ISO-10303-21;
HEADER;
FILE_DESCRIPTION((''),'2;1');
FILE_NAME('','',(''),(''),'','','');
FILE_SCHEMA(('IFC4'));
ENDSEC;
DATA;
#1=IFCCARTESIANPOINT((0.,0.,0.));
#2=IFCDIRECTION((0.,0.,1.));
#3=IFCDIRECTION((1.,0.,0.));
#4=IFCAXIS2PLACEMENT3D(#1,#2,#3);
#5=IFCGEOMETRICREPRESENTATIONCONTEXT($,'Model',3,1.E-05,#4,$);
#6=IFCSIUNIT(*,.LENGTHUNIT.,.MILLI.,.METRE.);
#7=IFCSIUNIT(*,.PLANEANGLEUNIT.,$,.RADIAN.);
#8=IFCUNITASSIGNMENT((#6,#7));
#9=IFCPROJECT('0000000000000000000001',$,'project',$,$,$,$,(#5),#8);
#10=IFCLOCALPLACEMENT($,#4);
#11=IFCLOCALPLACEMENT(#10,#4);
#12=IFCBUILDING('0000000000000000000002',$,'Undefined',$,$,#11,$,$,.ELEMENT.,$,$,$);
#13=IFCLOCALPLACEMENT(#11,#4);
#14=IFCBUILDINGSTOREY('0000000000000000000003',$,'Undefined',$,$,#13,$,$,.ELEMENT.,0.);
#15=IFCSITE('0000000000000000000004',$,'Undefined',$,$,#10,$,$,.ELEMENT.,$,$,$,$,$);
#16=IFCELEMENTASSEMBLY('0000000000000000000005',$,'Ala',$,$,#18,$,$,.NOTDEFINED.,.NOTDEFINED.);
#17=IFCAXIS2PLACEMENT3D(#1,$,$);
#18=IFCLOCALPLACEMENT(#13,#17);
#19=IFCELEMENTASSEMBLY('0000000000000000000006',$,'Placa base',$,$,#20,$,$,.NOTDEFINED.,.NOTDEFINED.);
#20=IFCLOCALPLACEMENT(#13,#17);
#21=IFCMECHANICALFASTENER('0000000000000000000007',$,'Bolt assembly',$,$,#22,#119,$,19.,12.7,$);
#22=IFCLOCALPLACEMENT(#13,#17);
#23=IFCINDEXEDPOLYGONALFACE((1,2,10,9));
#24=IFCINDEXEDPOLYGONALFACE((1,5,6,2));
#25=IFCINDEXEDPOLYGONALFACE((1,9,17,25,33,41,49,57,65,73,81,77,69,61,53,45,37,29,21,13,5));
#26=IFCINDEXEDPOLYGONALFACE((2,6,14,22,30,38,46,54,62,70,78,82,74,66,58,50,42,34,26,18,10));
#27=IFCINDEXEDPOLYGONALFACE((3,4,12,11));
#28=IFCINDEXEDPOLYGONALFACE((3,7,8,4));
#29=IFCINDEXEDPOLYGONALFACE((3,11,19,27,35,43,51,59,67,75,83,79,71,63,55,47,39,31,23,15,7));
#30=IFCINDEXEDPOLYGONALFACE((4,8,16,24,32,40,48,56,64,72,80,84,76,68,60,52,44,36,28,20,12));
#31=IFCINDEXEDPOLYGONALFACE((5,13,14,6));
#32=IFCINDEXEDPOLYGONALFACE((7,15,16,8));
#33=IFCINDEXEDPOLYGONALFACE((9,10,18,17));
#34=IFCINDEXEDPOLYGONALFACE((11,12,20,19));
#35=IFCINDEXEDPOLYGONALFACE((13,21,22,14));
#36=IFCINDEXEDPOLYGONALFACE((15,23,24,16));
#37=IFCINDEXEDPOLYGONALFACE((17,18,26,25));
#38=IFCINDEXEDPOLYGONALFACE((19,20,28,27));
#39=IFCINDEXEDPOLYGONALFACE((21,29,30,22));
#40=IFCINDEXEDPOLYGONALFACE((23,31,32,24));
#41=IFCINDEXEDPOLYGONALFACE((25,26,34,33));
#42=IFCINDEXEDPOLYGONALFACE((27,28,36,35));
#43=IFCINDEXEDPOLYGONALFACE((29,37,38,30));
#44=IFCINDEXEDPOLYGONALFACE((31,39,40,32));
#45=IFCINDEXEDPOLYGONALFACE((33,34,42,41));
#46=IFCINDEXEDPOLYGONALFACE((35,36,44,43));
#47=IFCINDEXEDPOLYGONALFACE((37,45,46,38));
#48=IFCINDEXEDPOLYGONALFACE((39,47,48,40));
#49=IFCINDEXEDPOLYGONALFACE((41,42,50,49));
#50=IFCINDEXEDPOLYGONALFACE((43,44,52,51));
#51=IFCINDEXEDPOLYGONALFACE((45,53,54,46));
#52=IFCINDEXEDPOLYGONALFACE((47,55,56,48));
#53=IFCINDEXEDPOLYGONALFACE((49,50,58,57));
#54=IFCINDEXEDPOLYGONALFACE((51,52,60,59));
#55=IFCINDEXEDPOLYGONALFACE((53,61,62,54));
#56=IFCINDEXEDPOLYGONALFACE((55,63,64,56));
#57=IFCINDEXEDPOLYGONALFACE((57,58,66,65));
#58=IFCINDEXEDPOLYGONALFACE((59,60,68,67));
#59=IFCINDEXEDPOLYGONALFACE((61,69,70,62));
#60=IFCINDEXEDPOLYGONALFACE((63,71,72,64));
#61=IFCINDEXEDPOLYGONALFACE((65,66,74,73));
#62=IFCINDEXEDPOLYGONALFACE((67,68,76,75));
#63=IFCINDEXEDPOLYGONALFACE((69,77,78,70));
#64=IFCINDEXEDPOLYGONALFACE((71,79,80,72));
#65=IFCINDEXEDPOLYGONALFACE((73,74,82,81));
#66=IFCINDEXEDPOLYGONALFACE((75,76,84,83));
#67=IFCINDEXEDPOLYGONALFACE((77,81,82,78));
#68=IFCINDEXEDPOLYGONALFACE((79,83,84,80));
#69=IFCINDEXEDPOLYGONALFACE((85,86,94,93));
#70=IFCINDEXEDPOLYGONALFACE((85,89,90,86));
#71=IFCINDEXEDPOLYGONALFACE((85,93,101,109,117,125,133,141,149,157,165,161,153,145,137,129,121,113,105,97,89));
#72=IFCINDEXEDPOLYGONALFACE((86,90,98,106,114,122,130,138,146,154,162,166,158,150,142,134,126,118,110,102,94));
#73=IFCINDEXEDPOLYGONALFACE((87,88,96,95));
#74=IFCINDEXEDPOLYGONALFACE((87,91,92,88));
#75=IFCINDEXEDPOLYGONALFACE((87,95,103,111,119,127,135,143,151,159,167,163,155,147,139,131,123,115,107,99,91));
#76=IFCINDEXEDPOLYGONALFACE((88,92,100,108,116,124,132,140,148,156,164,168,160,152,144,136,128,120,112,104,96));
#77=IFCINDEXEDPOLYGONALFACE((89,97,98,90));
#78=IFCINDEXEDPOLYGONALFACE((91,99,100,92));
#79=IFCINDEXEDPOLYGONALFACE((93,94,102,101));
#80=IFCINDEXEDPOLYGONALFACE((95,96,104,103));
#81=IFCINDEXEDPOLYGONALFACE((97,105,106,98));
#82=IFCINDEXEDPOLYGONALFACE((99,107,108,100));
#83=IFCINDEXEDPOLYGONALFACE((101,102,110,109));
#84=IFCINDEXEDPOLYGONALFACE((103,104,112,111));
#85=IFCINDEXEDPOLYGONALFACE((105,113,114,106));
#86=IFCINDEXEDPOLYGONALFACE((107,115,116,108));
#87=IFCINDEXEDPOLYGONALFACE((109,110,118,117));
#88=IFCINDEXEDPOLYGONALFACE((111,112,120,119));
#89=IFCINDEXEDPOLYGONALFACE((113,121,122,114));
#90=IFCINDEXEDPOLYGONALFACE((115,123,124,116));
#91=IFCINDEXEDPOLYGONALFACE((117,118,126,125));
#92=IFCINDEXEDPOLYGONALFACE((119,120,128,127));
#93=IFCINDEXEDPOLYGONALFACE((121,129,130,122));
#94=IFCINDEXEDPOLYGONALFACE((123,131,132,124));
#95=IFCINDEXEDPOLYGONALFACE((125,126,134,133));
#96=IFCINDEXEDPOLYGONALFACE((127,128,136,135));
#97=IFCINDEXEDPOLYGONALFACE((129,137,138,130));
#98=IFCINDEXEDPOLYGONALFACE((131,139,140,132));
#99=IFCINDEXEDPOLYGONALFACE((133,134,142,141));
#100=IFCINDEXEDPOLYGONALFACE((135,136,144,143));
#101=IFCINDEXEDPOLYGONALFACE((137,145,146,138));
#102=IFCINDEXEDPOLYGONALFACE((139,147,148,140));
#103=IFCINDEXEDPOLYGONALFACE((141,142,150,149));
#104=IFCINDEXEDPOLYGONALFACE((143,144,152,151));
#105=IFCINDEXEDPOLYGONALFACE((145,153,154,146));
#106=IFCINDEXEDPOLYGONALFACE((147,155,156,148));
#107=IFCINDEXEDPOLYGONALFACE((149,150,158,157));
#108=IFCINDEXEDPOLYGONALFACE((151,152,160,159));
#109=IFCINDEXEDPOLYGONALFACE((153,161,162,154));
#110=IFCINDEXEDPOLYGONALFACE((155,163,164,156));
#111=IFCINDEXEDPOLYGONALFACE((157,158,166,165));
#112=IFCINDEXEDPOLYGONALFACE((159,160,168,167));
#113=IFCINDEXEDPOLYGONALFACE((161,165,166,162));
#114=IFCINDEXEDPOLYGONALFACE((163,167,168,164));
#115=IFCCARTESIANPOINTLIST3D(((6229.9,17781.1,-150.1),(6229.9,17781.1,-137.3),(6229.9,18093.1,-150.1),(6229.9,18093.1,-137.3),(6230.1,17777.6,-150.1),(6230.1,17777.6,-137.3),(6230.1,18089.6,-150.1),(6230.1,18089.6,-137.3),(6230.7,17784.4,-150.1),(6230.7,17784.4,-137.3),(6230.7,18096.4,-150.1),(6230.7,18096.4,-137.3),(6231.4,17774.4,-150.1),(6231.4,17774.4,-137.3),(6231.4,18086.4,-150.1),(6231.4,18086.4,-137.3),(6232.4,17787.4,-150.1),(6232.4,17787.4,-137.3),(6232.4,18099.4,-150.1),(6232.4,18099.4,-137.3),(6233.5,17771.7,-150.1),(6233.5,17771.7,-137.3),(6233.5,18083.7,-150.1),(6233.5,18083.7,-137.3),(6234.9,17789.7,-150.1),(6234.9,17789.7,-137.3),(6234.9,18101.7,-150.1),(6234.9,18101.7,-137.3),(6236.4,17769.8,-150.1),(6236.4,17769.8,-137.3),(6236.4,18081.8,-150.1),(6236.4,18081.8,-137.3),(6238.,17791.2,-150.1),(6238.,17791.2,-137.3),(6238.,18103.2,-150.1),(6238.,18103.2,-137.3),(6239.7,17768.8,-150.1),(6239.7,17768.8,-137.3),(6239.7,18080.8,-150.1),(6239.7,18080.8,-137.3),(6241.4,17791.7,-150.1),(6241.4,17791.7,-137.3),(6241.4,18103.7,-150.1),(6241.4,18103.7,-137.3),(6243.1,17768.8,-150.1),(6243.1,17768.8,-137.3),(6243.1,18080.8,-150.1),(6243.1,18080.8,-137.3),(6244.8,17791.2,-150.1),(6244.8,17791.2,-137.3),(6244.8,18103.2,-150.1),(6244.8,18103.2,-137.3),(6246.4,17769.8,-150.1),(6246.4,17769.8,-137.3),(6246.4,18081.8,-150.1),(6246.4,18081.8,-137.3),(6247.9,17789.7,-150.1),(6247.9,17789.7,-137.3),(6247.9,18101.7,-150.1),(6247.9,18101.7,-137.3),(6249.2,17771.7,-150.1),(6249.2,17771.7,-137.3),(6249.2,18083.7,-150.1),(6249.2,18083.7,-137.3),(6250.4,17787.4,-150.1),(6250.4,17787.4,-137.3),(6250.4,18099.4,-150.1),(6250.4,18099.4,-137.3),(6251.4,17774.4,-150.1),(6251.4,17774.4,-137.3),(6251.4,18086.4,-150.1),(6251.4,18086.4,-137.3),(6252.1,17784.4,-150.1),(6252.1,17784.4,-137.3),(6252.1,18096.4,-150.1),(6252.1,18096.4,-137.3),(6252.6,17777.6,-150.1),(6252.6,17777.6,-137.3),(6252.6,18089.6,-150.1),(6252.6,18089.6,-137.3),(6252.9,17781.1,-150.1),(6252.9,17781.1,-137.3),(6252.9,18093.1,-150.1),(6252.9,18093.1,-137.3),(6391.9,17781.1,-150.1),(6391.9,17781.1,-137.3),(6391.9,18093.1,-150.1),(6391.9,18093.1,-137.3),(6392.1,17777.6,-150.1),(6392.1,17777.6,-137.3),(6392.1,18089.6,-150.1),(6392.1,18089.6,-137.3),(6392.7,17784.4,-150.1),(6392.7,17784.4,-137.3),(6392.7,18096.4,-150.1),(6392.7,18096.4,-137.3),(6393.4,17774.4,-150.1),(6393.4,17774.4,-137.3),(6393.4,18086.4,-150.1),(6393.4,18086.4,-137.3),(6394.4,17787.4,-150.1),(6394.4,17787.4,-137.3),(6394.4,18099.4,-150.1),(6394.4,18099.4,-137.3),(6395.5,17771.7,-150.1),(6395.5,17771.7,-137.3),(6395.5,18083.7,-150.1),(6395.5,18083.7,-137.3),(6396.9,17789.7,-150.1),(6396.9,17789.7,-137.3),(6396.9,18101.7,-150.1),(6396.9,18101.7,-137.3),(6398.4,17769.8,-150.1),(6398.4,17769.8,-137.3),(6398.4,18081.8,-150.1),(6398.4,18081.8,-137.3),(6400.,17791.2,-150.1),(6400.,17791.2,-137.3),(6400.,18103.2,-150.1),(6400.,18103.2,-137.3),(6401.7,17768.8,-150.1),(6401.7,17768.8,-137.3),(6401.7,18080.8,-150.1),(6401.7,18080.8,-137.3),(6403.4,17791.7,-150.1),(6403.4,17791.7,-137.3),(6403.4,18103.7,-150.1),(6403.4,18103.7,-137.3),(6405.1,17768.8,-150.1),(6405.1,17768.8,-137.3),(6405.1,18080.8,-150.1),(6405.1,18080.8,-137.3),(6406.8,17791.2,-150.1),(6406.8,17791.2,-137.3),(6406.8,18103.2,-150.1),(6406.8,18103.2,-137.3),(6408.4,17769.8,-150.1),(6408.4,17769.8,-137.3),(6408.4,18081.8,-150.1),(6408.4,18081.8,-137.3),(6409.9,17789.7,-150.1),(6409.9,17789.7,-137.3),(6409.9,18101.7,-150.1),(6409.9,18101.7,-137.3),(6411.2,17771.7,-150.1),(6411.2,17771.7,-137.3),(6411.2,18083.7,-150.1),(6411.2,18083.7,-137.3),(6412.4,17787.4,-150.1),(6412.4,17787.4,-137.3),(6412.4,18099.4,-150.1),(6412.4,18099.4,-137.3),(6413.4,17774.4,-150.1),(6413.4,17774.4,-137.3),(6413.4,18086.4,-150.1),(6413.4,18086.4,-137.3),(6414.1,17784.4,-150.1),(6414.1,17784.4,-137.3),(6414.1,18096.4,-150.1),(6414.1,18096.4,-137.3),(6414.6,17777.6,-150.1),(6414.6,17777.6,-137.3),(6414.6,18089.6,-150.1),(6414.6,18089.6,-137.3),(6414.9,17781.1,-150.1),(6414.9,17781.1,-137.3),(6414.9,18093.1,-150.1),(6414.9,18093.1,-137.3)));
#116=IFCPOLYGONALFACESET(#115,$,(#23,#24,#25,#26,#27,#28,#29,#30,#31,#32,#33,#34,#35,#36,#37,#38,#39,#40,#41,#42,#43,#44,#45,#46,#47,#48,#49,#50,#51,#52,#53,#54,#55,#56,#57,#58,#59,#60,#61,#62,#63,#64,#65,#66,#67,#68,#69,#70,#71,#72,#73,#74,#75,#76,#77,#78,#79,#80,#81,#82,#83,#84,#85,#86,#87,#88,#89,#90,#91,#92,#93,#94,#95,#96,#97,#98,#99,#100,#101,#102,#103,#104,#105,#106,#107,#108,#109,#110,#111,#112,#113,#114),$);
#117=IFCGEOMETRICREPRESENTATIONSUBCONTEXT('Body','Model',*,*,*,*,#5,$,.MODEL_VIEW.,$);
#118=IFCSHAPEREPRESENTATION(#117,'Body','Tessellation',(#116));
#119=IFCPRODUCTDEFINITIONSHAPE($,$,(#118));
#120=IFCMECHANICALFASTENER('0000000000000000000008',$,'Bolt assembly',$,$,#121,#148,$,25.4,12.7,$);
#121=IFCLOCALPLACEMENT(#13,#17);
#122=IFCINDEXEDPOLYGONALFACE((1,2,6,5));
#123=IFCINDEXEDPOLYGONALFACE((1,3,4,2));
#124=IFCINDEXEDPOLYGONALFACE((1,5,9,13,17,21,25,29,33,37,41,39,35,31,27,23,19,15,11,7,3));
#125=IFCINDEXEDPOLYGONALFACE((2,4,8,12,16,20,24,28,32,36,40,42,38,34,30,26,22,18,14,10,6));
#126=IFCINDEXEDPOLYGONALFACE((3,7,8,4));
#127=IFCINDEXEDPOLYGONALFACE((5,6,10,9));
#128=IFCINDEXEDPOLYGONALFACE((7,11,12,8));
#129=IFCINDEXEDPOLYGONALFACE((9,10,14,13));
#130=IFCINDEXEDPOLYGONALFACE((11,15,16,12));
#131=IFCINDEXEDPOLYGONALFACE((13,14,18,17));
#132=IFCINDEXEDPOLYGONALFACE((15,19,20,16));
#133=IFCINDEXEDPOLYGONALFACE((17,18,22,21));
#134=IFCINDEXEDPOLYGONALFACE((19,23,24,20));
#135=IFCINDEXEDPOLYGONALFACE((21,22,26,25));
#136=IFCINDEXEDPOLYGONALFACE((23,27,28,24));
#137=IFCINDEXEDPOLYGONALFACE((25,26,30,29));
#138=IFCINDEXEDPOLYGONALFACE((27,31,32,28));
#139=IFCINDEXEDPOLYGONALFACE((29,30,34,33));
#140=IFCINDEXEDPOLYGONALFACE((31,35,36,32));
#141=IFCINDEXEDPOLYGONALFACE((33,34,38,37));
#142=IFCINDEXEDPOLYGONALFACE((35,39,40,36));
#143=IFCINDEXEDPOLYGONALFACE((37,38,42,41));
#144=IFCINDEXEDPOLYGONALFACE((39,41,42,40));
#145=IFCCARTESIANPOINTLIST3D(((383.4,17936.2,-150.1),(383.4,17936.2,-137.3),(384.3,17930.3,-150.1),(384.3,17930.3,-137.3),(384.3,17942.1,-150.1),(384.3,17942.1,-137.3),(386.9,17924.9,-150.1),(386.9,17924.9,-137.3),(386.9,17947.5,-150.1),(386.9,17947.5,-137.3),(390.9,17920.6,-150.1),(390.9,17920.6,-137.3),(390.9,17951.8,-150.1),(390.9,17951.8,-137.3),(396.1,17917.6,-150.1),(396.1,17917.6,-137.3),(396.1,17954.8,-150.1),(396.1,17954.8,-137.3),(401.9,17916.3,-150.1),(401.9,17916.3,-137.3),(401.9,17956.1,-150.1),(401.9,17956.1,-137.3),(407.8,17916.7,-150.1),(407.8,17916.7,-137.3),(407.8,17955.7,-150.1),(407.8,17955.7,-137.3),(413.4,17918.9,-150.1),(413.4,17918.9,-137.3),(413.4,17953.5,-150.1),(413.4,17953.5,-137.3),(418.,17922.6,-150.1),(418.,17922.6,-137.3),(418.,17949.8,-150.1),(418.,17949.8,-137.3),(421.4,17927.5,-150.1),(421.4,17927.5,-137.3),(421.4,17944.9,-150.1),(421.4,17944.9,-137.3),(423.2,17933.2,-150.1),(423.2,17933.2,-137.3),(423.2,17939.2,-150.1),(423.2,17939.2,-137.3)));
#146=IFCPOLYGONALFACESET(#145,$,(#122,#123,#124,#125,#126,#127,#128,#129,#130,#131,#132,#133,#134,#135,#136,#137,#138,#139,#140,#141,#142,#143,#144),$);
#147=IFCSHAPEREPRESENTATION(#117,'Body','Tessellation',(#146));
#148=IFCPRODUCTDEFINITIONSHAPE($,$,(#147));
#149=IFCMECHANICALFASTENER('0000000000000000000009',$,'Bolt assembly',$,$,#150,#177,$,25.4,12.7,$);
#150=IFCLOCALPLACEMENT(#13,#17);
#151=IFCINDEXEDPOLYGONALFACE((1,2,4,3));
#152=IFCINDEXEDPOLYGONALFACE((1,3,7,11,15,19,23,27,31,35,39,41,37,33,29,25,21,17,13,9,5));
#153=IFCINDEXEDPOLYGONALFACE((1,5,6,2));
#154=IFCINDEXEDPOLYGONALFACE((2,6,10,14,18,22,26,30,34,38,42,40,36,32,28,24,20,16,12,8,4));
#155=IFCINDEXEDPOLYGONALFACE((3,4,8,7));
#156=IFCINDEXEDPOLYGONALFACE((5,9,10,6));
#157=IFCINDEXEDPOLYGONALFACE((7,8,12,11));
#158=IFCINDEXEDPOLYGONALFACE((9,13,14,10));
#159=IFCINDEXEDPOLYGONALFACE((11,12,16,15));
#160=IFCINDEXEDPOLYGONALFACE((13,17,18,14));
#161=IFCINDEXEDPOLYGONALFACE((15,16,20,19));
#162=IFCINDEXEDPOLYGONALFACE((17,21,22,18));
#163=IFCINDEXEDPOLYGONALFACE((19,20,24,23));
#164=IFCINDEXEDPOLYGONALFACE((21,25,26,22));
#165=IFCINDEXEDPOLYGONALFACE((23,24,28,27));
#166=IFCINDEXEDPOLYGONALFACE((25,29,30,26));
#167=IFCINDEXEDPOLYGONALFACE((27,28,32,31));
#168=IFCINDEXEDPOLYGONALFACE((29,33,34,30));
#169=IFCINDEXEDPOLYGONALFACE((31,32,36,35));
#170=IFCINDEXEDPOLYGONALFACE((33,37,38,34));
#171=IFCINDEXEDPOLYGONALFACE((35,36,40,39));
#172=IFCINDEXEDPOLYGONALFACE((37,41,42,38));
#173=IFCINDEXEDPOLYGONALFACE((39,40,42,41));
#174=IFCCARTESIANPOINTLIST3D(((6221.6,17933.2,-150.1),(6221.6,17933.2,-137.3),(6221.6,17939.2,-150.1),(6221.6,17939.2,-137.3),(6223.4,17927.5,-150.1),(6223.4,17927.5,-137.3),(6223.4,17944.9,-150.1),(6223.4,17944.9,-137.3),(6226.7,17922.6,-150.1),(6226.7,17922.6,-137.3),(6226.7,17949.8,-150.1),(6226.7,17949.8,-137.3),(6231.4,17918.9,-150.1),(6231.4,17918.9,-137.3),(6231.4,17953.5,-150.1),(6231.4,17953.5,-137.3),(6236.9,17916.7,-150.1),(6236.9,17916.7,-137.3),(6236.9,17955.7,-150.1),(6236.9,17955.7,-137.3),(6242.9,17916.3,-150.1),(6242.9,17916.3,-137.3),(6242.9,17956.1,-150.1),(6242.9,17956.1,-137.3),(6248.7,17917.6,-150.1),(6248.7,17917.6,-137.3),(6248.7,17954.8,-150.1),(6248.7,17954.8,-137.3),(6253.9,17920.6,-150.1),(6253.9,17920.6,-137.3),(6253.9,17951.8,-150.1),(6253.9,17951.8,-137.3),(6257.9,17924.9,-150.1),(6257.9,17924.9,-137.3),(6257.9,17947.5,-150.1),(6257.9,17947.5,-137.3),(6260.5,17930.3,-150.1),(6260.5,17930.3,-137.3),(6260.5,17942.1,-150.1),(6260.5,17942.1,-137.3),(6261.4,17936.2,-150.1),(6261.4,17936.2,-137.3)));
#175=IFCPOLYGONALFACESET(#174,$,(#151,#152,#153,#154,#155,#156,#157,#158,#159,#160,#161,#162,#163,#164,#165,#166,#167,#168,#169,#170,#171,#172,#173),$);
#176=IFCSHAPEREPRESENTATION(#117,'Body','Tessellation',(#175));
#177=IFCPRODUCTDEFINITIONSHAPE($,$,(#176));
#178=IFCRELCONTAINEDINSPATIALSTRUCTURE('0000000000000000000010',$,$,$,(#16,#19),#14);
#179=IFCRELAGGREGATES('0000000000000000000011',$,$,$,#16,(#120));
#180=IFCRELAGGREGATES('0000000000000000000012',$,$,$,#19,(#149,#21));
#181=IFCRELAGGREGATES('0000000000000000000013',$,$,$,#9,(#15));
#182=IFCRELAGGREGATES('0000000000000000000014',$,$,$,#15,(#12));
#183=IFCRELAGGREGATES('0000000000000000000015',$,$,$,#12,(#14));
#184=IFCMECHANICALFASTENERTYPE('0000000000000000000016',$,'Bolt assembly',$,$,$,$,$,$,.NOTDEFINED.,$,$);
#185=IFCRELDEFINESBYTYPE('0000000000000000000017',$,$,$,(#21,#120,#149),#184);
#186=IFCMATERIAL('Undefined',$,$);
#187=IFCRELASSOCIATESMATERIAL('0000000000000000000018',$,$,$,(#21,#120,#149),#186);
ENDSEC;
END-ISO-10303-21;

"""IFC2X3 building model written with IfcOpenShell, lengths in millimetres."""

from ifc_helpers import new_model, si_unit, frame, origin_with_axes, origin_2d_with_axis, place, context, subcontext, project, spatial, circle, extrude, source, transform, mapped, material, type_object, element, aggregate, save


model = new_model("IFC2X3")

# Units and contexts
model_context = context("Model", 3, precision=1e-05, world=origin_with_axes())
body_context = subcontext(model_context, "Body", "Model", "MODEL_VIEW")
ifc_project = project(units=[si_unit("LENGTHUNIT", "METRE", prefix="MILLI"), si_unit("PLANEANGLEUNIT", "RADIAN")], contexts=[model_context])

# Site, building, storey
site_placement = place(None, origin_with_axes())
site = spatial("IfcSite", under=ifc_project, at=site_placement, Name="Undefined", CompositionType="ELEMENT")
building_placement = place(site_placement, origin_with_axes())
building = spatial("IfcBuilding", under=site, at=building_placement, Name="Undefined", CompositionType="ELEMENT")
storey_placement = place(building_placement, origin_with_axes())
storey = spatial("IfcBuildingStorey", under=building, at=storey_placement, Name="Undefined", CompositionType="ELEMENT", Elevation=0.0)

# Element assemblies
assembly_1_placement = place(storey_placement, origin_with_axes())
assembly_1 = element("IfcElementAssembly", 1, at=assembly_1_placement, inside=storey, Name="Ala", AssemblyPlace="NOTDEFINED", PredefinedType="NOTDEFINED")
assembly_2_placement = place(storey_placement, origin_with_axes())
assembly_2 = element("IfcElementAssembly", 2, at=assembly_2_placement, inside=storey, Name="Placa base", AssemblyPlace="NOTDEFINED", PredefinedType="NOTDEFINED")

# Mechanical fasteners
ifc_material_1 = material(Name="Undefined")
mechanical_fastener_type = type_object("IfcMechanicalFastenerType", Name="Bolt assembly")
shared_shape_1 = source(origin_with_axes(), body_context, "Body", "SweptSolid", [
    extrude(circle(Radius=11.5, at=origin_2d_with_axis()), frame((0.0, 0.0, 0.0), z_axis=(0.0, 1.0, 0.0), x_axis=(1.0, 0.0, 0.0)), (0.0, 0.0, 1.0), 12.8),
])
mechanical_fastener_1_placement = place(assembly_2_placement, frame((6322.4, 17780.2, -137.3), z_axis=(-1.0, 0.0, 0.0), x_axis=(0.0, 1.0, 0.0)))
mechanical_fastener_1 = element("IfcMechanicalFastener", 3, at=mechanical_fastener_1_placement, type_object=mechanical_fastener_type, material=ifc_material_1, Name="Bolt assembly", NominalDiameter=19.0, NominalLength=12.7, context=body_context, shape_type="MappedRepresentation", body=[
    mapped(shared_shape_1, transform((0.0, 0.0, -81.0))),
    mapped(shared_shape_1, transform((312.0, 0.0, -81.0))),
    mapped(shared_shape_1, transform((0.0, 0.0, 81.0))),
    mapped(shared_shape_1, transform((312.0, 0.0, 81.0))),
])
shared_shape_2 = source(origin_with_axes(), body_context, "Body", "SweptSolid", [
    extrude(circle(Radius=20.0, at=origin_2d_with_axis()), frame((0.0, -12.7, 0.0), z_axis=(0.0, 1.0, 0.0), x_axis=(1.0, 0.0, 0.0)), (0.0, 0.0, 1.0), 12.8),
])
mechanical_fastener_2_placement = place(assembly_1_placement, frame((403.4, 17936.2, -150.0), z_axis=(0.0, -1.0, 0.0), x_axis=(-1.0, 0.0, 0.0)))
mechanical_fastener_2 = element("IfcMechanicalFastener", 4, at=mechanical_fastener_2_placement, type_object=mechanical_fastener_type, material=ifc_material_1, Name="Bolt assembly", NominalDiameter=25.4, NominalLength=12.7, context=body_context, shape_type="MappedRepresentation", body=[
    mapped(shared_shape_2, transform((0.0, 0.0, 0.0))),
])
aggregate(assembly_1, [mechanical_fastener_2])
mechanical_fastener_3_placement = place(assembly_2_placement, frame((6241.4, 17936.2, -150.0), z_axis=(0.0, 1.0, 0.0), x_axis=(1.0, 0.0, 0.0)))
mechanical_fastener_3 = element("IfcMechanicalFastener", 5, at=mechanical_fastener_3_placement, type_object=mechanical_fastener_type, material=ifc_material_1, Name="Bolt assembly", NominalDiameter=25.4, NominalLength=12.7, context=body_context, shape_type="MappedRepresentation", body=[
    mapped(shared_shape_2, transform((0.0, 0.0, 0.0))),
])
aggregate(assembly_2, [mechanical_fastener_3, mechanical_fastener_1])

save(model, "model.ifc")
